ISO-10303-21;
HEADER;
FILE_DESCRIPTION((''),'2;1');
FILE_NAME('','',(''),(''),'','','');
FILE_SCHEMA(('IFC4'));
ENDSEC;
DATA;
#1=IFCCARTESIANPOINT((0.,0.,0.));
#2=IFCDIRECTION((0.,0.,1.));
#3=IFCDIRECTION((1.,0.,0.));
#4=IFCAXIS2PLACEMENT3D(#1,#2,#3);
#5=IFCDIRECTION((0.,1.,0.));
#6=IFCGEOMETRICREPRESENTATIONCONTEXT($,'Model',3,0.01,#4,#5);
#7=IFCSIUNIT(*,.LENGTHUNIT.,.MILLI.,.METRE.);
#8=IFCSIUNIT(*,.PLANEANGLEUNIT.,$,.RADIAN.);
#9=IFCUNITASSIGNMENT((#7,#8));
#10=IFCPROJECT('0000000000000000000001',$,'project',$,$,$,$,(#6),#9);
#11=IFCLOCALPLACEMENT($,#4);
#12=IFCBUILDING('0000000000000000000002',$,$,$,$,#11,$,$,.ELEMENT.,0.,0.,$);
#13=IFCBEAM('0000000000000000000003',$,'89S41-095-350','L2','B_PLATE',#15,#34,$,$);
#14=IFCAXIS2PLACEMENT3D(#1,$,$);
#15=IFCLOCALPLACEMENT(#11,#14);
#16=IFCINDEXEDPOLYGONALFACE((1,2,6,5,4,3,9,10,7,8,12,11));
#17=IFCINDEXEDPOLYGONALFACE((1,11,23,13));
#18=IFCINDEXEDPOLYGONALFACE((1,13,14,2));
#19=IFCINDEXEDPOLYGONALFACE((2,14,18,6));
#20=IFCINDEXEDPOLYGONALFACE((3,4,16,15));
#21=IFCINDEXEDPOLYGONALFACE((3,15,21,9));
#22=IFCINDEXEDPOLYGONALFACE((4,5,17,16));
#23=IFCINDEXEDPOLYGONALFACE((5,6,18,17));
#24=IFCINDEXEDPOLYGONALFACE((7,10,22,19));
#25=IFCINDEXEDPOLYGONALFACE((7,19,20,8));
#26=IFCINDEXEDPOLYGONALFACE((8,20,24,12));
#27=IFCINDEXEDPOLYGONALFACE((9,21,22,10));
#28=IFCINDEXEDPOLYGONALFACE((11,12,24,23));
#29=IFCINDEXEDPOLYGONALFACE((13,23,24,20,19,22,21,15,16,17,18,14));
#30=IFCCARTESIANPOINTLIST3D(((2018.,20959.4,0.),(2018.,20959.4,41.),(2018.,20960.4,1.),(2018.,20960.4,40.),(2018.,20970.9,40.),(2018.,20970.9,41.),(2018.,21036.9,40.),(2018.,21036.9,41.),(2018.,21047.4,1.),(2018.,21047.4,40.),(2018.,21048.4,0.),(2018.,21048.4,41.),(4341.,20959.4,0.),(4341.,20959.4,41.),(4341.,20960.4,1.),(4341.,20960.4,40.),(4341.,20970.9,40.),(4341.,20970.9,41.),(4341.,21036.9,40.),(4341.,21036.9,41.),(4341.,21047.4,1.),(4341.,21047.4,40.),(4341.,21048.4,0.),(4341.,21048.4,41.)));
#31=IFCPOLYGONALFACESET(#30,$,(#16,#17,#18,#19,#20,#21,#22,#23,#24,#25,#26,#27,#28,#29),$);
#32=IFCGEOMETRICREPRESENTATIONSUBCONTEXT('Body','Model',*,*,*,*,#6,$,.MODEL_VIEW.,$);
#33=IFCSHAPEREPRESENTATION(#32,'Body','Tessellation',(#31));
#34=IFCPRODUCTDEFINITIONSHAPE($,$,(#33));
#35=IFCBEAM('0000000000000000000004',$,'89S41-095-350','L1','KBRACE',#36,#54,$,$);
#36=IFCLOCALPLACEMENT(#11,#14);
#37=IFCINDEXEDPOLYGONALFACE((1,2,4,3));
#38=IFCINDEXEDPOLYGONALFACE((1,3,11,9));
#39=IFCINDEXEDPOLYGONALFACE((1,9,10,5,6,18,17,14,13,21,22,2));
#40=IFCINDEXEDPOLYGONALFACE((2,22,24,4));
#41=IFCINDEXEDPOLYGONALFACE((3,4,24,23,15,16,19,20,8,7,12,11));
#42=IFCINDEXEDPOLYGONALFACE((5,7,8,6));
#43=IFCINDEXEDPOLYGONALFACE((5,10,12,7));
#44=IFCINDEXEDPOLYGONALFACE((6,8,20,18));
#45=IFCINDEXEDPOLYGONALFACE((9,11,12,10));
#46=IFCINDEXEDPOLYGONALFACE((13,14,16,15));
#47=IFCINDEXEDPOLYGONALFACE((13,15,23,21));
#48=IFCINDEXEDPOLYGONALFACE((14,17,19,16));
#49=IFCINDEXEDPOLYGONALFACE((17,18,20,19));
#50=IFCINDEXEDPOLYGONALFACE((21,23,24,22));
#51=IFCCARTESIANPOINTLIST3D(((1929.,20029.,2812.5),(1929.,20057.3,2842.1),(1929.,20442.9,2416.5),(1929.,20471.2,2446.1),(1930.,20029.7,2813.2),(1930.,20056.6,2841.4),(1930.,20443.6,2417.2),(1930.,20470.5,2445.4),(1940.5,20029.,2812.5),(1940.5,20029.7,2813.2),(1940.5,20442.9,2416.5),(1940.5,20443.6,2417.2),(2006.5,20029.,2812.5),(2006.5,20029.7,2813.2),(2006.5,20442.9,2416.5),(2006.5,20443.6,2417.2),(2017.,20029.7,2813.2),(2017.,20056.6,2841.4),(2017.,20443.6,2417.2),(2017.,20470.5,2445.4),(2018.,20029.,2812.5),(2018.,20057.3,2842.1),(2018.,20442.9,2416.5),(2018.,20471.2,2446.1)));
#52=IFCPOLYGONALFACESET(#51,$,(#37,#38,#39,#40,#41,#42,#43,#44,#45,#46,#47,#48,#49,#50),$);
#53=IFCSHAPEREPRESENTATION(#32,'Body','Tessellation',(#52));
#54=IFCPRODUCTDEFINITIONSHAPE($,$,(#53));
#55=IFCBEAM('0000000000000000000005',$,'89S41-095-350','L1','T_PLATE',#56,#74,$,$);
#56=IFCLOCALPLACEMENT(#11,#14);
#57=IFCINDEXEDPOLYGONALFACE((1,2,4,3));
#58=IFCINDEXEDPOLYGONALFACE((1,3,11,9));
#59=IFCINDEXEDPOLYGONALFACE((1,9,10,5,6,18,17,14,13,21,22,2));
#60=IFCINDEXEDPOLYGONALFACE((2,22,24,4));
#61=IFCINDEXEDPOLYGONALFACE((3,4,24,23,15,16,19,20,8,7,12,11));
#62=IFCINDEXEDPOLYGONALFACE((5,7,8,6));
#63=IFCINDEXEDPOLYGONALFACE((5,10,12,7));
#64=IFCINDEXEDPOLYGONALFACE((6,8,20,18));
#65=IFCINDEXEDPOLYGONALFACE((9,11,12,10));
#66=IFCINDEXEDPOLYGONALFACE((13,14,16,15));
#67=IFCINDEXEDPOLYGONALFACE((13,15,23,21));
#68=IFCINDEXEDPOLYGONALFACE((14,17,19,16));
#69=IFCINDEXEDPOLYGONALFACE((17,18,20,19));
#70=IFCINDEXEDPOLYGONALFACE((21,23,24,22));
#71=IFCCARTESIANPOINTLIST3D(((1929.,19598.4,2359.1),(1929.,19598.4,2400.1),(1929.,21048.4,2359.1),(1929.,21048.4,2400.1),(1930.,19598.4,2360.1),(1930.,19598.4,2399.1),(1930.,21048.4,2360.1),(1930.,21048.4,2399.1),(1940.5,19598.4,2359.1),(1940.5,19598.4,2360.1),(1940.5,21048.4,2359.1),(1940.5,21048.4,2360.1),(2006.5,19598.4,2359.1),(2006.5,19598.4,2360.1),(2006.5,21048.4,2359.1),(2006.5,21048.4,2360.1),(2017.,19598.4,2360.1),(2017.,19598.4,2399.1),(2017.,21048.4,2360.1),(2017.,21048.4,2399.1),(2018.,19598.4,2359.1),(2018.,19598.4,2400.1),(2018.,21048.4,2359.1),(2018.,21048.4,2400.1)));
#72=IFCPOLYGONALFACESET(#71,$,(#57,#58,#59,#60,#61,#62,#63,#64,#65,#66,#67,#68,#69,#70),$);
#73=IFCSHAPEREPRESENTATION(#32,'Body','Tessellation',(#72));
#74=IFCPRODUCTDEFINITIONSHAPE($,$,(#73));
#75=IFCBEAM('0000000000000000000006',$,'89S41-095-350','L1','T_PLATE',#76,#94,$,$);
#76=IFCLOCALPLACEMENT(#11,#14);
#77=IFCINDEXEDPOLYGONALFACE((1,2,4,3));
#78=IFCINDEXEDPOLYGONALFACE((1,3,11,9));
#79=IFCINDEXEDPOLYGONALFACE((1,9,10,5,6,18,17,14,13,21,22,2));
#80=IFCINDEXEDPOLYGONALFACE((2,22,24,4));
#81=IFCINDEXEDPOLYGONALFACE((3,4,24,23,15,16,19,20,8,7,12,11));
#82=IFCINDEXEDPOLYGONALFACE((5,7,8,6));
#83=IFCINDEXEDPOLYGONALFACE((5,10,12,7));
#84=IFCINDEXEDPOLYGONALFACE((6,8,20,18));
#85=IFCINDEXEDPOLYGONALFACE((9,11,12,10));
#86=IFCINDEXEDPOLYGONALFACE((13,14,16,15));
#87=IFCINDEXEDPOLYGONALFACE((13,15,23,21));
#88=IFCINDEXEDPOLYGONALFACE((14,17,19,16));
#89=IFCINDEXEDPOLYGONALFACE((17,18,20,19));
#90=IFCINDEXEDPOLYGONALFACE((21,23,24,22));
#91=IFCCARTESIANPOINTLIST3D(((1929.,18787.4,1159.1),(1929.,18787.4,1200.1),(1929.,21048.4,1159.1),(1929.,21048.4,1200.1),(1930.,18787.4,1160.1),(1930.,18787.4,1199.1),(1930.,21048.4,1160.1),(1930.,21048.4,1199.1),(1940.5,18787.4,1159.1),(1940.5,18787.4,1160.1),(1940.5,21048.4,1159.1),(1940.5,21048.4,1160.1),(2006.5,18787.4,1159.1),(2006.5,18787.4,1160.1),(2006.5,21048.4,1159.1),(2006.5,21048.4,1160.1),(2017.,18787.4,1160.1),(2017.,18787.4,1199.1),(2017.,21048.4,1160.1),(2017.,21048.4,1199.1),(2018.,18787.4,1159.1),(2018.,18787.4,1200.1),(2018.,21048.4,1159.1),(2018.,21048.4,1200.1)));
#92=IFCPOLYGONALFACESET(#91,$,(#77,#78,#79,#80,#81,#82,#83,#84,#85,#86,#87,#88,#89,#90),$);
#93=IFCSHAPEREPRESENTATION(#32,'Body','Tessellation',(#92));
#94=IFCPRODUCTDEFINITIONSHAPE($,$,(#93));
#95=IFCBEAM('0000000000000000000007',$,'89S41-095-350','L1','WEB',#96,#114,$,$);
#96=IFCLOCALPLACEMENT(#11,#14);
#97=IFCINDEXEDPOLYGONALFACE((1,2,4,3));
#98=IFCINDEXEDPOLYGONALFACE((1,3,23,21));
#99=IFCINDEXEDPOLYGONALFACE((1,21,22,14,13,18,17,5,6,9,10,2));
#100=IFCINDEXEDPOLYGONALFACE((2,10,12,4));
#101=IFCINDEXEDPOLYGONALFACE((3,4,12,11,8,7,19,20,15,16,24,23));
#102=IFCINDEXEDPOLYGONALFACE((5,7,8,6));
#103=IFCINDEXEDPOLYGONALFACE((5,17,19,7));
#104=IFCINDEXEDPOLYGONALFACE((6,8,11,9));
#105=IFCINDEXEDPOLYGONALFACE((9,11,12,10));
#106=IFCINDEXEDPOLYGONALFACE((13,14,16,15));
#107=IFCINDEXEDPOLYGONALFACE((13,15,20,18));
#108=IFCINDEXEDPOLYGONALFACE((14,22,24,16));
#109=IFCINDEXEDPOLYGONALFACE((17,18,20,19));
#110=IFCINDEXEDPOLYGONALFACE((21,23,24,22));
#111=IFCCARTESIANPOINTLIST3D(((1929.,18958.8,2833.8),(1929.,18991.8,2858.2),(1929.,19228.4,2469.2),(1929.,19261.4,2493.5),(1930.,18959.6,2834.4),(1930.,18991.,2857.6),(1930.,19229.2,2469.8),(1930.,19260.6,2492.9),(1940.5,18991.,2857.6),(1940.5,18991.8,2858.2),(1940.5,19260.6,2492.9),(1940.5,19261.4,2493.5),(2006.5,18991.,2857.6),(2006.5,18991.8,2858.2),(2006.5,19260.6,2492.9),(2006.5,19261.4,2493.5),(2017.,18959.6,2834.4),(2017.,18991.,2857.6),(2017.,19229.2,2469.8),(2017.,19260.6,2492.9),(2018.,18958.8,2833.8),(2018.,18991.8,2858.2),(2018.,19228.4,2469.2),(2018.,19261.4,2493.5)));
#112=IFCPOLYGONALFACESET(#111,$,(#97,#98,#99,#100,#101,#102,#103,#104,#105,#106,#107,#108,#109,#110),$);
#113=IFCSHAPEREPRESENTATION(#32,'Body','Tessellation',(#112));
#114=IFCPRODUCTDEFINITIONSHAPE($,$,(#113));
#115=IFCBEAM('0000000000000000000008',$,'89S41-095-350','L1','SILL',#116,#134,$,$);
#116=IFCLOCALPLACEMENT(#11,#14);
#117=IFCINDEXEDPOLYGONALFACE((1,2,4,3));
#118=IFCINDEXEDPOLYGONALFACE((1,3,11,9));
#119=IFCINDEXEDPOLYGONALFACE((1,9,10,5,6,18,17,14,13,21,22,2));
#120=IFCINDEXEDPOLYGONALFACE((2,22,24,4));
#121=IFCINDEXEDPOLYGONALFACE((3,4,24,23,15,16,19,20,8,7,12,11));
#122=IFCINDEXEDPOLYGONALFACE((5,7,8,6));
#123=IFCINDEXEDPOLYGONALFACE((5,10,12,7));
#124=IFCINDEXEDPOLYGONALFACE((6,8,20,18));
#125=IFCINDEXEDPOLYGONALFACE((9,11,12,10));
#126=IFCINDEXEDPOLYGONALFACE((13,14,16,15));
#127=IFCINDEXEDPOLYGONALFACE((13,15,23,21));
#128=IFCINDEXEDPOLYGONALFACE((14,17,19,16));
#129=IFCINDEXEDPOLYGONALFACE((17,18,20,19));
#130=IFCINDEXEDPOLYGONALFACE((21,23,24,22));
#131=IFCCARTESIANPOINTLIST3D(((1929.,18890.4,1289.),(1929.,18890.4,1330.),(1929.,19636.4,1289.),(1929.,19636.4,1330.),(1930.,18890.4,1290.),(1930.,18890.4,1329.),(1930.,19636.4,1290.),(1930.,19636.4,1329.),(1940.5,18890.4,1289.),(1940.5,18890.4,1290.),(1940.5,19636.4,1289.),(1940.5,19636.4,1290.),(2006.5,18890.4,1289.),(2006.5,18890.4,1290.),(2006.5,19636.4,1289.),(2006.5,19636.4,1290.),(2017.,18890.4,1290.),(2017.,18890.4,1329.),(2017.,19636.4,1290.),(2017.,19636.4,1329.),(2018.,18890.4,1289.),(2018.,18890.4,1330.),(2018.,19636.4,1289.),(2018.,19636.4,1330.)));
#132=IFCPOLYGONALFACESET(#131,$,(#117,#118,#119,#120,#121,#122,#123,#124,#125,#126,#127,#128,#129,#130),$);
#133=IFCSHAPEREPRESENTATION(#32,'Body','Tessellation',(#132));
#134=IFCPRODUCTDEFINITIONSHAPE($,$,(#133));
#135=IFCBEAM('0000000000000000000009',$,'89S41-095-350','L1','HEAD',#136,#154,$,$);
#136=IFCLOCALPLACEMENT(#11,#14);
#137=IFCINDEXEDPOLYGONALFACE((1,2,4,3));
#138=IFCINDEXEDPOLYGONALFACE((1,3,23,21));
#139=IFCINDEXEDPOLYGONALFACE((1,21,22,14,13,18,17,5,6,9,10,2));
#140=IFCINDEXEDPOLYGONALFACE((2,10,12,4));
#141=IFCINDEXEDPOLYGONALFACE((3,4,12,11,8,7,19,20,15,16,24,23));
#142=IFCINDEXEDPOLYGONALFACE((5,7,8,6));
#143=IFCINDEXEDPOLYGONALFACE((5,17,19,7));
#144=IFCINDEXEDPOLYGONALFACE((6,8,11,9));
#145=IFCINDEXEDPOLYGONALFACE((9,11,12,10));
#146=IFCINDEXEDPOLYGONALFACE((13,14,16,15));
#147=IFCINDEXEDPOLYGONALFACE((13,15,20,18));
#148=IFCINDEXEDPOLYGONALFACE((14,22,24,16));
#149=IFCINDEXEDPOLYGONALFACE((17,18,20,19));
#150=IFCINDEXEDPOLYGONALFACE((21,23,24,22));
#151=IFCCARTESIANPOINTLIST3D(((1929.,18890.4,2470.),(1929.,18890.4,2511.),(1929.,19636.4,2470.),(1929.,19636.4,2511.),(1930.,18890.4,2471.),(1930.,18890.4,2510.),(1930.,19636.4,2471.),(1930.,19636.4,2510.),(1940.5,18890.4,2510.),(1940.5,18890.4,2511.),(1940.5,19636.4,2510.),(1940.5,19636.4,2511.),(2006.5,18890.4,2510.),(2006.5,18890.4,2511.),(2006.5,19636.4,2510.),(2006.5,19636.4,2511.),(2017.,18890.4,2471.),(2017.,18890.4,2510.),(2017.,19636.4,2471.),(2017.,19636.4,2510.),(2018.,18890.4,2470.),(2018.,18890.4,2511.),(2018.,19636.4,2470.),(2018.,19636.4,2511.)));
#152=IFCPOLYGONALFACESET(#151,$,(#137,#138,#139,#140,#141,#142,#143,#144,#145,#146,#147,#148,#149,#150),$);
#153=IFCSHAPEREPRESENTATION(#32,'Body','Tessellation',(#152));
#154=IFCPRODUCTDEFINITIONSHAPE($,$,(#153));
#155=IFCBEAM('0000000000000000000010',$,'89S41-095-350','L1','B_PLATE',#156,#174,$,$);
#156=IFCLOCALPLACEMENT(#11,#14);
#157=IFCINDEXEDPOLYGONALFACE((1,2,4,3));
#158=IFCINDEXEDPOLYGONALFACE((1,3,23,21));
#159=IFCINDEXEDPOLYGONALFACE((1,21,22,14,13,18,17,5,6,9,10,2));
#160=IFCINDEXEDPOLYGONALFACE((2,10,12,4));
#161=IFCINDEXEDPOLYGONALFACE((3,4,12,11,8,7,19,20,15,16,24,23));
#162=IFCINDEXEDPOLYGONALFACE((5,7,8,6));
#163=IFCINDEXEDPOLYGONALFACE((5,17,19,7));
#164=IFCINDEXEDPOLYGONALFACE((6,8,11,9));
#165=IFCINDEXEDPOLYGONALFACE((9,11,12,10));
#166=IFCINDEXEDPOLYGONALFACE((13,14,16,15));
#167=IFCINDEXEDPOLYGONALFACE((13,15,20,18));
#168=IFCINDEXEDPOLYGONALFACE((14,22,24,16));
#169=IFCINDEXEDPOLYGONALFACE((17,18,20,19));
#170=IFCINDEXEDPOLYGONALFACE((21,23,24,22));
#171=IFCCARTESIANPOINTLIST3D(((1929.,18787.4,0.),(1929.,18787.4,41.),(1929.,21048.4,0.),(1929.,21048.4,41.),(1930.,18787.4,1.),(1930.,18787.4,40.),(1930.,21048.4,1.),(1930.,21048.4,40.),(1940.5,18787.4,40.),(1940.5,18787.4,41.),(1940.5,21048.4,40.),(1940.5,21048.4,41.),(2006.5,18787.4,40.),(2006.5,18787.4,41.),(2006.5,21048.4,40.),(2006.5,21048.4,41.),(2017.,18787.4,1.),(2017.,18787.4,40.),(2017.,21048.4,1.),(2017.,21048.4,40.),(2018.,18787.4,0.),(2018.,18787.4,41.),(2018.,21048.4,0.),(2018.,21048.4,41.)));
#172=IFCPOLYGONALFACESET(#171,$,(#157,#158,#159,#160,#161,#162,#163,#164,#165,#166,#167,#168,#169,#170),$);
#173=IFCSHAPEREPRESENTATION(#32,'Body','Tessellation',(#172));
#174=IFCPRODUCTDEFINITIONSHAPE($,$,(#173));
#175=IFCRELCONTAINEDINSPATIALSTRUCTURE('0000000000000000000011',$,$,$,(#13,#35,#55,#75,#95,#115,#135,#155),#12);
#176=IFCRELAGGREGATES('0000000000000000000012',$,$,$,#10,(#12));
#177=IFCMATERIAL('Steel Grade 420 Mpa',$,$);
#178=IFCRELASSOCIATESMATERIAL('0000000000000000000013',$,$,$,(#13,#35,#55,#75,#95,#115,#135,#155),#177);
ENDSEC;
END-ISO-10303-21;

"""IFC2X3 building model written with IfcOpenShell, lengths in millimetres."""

from ifc_helpers import new_model, si_unit, direction, frame, origin, origin_with_axes, origin_2d_with_axis, place, context, subcontext, project, spatial, c_section, extrude, source, transform, mapped, material, element, save


model = new_model("IFC2X3")

# Units and contexts
model_context = context("Model", 3, precision=0.01, world=origin_with_axes(), true_north=direction((0.0, 1.0, 0.0)))
body_context = subcontext(model_context, "Body", "Model", "MODEL_VIEW")
ifc_project = project(units=[si_unit("LENGTHUNIT", "METRE", prefix="MILLI"), si_unit("PLANEANGLEUNIT", "RADIAN")], contexts=[model_context])

# Building
building_placement = place(None, origin_with_axes())
building = spatial("IfcBuilding", under=ifc_project, at=building_placement, CompositionType="ELEMENT", ElevationOfRefHeight=0.0, ElevationOfTerrain=0.0)

# Shared definitions
ifc_material = material(Name="Steel Grade 420 Mpa")

# Beams
shared_shape_1 = source(origin(), body_context, "Body", "SweptSolid", [
    extrude(c_section(Depth=89.0, Width=41.0, WallThickness=1.0, Girth=11.5, at=origin_2d_with_axis()), origin_with_axes(), (0.0, 0.0, 1.0), 2323.0),
])
beam_1_placement = place(None, frame((2018.0, 21003.9, 20.5), z_axis=(1.0, 0.0, 0.0), x_axis=(0.0, 0.0, 1.0)))
element("IfcBeam", 1, at=beam_1_placement, inside=building, material=ifc_material, Name="89S41-095-350", Description="L2", ObjectType="B_PLATE", context=body_context, shape_type="MappedRepresentation", body=[
    mapped(shared_shape_1, transform((0.0, 0.0, 0.0), scale=1.0)),
])
shared_shape_2 = source(origin(), body_context, "Body", "SweptSolid", [
    extrude(c_section(Depth=89.0, Width=41.0, WallThickness=1.0, Girth=11.5, at=origin_2d_with_axis()), origin_with_axes(), (0.0, 0.0, 1.0), 572.8),
])
beam_2_placement = place(None, frame((1973.5, 20457.0, 2431.3), z_axis=(0.0, -0.72257, 0.691297), x_axis=(0.0, -0.691297, -0.72257)))
element("IfcBeam", 2, at=beam_2_placement, inside=building, material=ifc_material, Name="89S41-095-350", Description="L1", ObjectType="KBRACE", context=body_context, shape_type="MappedRepresentation", body=[
    mapped(shared_shape_2, transform((0.0, 0.0, 0.0), scale=1.0)),
])
shared_shape_3 = source(origin(), body_context, "Body", "SweptSolid", [
    extrude(c_section(Depth=89.0, Width=41.0, WallThickness=1.0, Girth=11.5, at=origin_2d_with_axis()), origin_with_axes(), (0.0, 0.0, 1.0), 1450.0),
])
beam_3_placement = place(None, frame((1973.5, 21048.4, 2379.6), z_axis=(0.0, -1.0, 0.0), x_axis=(0.0, 0.0, -1.0)))
element("IfcBeam", 3, at=beam_3_placement, inside=building, material=ifc_material, Name="89S41-095-350", Description="L1", ObjectType="T_PLATE", context=body_context, shape_type="MappedRepresentation", body=[
    mapped(shared_shape_3, transform((0.0, 0.0, 0.0), scale=1.0)),
])
shared_shape_4 = source(origin(), body_context, "Body", "SweptSolid", [
    extrude(c_section(Depth=89.0, Width=41.0, WallThickness=1.0, Girth=11.5, at=origin_2d_with_axis()), origin_with_axes(), (0.0, 0.0, 1.0), 2261.0),
])
beam_4_placement = place(None, frame((1973.5, 21048.4, 1179.6), z_axis=(0.0, -1.0, 0.0), x_axis=(0.0, 0.0, -1.0)))
element("IfcBeam", 4, at=beam_4_placement, inside=building, material=ifc_material, Name="89S41-095-350", Description="L1", ObjectType="T_PLATE", context=body_context, shape_type="MappedRepresentation", body=[
    mapped(shared_shape_4, transform((0.0, 0.0, 0.0), scale=1.0)),
])
shared_shape_5 = source(origin(), body_context, "Body", "SweptSolid", [
    extrude(c_section(Depth=89.0, Width=41.0, WallThickness=1.0, Girth=11.5, at=origin_2d_with_axis()), origin_with_axes(), (0.0, 0.0, 1.0), 453.5),
])
beam_5_placement = place(None, frame((1973.5, 19244.9, 2481.4), z_axis=(0.0, -0.594477, 0.804112), x_axis=(0.0, 0.804112, 0.594477)))
element("IfcBeam", 5, at=beam_5_placement, inside=building, material=ifc_material, Name="89S41-095-350", Description="L1", ObjectType="WEB", context=body_context, shape_type="MappedRepresentation", body=[
    mapped(shared_shape_5, transform((0.0, 0.0, 0.0), scale=1.0)),
])
shared_shape_6 = source(origin(), body_context, "Body", "SweptSolid", [
    extrude(c_section(Depth=89.0, Width=41.0, WallThickness=1.0, Girth=11.5, at=origin_2d_with_axis()), origin_with_axes(), (0.0, 0.0, 1.0), 746.0),
])
beam_6_placement = place(None, frame((1973.5, 19636.4, 1309.5), z_axis=(0.0, -1.0, 0.0), x_axis=(0.0, 0.0, -1.0)))
element("IfcBeam", 6, at=beam_6_placement, inside=building, material=ifc_material, Name="89S41-095-350", Description="L1", ObjectType="SILL", context=body_context, shape_type="MappedRepresentation", body=[
    mapped(shared_shape_6, transform((0.0, 0.0, 0.0), scale=1.0)),
])
shared_shape_7 = source(origin(), body_context, "Body", "SweptSolid", [
    extrude(c_section(Depth=89.0, Width=41.0, WallThickness=1.0, Girth=11.5, at=origin_2d_with_axis()), origin_with_axes(), (0.0, 0.0, 1.0), 746.0),
])
beam_7_placement = place(None, frame((1973.5, 19636.4, 2490.5), z_axis=(0.0, -1.0, 0.0), x_axis=(0.0, 0.0, 1.0)))
element("IfcBeam", 7, at=beam_7_placement, inside=building, material=ifc_material, Name="89S41-095-350", Description="L1", ObjectType="HEAD", context=body_context, shape_type="MappedRepresentation", body=[
    mapped(shared_shape_7, transform((0.0, 0.0, 0.0), scale=1.0)),
])
shared_shape_8 = source(origin(), body_context, "Body", "SweptSolid", [
    extrude(c_section(Depth=89.0, Width=41.0, WallThickness=1.0, Girth=11.5, at=origin_2d_with_axis()), origin_with_axes(), (0.0, 0.0, 1.0), 2261.0),
])
beam_8_placement = place(None, frame((1973.5, 21048.4, 20.5), z_axis=(0.0, -1.0, 0.0), x_axis=(0.0, 0.0, 1.0)))
element("IfcBeam", 8, at=beam_8_placement, inside=building, material=ifc_material, Name="89S41-095-350", Description="L1", ObjectType="B_PLATE", context=body_context, shape_type="MappedRepresentation", body=[
    mapped(shared_shape_8, transform((0.0, 0.0, 0.0), scale=1.0)),
])

save(model, "model.ifc")
